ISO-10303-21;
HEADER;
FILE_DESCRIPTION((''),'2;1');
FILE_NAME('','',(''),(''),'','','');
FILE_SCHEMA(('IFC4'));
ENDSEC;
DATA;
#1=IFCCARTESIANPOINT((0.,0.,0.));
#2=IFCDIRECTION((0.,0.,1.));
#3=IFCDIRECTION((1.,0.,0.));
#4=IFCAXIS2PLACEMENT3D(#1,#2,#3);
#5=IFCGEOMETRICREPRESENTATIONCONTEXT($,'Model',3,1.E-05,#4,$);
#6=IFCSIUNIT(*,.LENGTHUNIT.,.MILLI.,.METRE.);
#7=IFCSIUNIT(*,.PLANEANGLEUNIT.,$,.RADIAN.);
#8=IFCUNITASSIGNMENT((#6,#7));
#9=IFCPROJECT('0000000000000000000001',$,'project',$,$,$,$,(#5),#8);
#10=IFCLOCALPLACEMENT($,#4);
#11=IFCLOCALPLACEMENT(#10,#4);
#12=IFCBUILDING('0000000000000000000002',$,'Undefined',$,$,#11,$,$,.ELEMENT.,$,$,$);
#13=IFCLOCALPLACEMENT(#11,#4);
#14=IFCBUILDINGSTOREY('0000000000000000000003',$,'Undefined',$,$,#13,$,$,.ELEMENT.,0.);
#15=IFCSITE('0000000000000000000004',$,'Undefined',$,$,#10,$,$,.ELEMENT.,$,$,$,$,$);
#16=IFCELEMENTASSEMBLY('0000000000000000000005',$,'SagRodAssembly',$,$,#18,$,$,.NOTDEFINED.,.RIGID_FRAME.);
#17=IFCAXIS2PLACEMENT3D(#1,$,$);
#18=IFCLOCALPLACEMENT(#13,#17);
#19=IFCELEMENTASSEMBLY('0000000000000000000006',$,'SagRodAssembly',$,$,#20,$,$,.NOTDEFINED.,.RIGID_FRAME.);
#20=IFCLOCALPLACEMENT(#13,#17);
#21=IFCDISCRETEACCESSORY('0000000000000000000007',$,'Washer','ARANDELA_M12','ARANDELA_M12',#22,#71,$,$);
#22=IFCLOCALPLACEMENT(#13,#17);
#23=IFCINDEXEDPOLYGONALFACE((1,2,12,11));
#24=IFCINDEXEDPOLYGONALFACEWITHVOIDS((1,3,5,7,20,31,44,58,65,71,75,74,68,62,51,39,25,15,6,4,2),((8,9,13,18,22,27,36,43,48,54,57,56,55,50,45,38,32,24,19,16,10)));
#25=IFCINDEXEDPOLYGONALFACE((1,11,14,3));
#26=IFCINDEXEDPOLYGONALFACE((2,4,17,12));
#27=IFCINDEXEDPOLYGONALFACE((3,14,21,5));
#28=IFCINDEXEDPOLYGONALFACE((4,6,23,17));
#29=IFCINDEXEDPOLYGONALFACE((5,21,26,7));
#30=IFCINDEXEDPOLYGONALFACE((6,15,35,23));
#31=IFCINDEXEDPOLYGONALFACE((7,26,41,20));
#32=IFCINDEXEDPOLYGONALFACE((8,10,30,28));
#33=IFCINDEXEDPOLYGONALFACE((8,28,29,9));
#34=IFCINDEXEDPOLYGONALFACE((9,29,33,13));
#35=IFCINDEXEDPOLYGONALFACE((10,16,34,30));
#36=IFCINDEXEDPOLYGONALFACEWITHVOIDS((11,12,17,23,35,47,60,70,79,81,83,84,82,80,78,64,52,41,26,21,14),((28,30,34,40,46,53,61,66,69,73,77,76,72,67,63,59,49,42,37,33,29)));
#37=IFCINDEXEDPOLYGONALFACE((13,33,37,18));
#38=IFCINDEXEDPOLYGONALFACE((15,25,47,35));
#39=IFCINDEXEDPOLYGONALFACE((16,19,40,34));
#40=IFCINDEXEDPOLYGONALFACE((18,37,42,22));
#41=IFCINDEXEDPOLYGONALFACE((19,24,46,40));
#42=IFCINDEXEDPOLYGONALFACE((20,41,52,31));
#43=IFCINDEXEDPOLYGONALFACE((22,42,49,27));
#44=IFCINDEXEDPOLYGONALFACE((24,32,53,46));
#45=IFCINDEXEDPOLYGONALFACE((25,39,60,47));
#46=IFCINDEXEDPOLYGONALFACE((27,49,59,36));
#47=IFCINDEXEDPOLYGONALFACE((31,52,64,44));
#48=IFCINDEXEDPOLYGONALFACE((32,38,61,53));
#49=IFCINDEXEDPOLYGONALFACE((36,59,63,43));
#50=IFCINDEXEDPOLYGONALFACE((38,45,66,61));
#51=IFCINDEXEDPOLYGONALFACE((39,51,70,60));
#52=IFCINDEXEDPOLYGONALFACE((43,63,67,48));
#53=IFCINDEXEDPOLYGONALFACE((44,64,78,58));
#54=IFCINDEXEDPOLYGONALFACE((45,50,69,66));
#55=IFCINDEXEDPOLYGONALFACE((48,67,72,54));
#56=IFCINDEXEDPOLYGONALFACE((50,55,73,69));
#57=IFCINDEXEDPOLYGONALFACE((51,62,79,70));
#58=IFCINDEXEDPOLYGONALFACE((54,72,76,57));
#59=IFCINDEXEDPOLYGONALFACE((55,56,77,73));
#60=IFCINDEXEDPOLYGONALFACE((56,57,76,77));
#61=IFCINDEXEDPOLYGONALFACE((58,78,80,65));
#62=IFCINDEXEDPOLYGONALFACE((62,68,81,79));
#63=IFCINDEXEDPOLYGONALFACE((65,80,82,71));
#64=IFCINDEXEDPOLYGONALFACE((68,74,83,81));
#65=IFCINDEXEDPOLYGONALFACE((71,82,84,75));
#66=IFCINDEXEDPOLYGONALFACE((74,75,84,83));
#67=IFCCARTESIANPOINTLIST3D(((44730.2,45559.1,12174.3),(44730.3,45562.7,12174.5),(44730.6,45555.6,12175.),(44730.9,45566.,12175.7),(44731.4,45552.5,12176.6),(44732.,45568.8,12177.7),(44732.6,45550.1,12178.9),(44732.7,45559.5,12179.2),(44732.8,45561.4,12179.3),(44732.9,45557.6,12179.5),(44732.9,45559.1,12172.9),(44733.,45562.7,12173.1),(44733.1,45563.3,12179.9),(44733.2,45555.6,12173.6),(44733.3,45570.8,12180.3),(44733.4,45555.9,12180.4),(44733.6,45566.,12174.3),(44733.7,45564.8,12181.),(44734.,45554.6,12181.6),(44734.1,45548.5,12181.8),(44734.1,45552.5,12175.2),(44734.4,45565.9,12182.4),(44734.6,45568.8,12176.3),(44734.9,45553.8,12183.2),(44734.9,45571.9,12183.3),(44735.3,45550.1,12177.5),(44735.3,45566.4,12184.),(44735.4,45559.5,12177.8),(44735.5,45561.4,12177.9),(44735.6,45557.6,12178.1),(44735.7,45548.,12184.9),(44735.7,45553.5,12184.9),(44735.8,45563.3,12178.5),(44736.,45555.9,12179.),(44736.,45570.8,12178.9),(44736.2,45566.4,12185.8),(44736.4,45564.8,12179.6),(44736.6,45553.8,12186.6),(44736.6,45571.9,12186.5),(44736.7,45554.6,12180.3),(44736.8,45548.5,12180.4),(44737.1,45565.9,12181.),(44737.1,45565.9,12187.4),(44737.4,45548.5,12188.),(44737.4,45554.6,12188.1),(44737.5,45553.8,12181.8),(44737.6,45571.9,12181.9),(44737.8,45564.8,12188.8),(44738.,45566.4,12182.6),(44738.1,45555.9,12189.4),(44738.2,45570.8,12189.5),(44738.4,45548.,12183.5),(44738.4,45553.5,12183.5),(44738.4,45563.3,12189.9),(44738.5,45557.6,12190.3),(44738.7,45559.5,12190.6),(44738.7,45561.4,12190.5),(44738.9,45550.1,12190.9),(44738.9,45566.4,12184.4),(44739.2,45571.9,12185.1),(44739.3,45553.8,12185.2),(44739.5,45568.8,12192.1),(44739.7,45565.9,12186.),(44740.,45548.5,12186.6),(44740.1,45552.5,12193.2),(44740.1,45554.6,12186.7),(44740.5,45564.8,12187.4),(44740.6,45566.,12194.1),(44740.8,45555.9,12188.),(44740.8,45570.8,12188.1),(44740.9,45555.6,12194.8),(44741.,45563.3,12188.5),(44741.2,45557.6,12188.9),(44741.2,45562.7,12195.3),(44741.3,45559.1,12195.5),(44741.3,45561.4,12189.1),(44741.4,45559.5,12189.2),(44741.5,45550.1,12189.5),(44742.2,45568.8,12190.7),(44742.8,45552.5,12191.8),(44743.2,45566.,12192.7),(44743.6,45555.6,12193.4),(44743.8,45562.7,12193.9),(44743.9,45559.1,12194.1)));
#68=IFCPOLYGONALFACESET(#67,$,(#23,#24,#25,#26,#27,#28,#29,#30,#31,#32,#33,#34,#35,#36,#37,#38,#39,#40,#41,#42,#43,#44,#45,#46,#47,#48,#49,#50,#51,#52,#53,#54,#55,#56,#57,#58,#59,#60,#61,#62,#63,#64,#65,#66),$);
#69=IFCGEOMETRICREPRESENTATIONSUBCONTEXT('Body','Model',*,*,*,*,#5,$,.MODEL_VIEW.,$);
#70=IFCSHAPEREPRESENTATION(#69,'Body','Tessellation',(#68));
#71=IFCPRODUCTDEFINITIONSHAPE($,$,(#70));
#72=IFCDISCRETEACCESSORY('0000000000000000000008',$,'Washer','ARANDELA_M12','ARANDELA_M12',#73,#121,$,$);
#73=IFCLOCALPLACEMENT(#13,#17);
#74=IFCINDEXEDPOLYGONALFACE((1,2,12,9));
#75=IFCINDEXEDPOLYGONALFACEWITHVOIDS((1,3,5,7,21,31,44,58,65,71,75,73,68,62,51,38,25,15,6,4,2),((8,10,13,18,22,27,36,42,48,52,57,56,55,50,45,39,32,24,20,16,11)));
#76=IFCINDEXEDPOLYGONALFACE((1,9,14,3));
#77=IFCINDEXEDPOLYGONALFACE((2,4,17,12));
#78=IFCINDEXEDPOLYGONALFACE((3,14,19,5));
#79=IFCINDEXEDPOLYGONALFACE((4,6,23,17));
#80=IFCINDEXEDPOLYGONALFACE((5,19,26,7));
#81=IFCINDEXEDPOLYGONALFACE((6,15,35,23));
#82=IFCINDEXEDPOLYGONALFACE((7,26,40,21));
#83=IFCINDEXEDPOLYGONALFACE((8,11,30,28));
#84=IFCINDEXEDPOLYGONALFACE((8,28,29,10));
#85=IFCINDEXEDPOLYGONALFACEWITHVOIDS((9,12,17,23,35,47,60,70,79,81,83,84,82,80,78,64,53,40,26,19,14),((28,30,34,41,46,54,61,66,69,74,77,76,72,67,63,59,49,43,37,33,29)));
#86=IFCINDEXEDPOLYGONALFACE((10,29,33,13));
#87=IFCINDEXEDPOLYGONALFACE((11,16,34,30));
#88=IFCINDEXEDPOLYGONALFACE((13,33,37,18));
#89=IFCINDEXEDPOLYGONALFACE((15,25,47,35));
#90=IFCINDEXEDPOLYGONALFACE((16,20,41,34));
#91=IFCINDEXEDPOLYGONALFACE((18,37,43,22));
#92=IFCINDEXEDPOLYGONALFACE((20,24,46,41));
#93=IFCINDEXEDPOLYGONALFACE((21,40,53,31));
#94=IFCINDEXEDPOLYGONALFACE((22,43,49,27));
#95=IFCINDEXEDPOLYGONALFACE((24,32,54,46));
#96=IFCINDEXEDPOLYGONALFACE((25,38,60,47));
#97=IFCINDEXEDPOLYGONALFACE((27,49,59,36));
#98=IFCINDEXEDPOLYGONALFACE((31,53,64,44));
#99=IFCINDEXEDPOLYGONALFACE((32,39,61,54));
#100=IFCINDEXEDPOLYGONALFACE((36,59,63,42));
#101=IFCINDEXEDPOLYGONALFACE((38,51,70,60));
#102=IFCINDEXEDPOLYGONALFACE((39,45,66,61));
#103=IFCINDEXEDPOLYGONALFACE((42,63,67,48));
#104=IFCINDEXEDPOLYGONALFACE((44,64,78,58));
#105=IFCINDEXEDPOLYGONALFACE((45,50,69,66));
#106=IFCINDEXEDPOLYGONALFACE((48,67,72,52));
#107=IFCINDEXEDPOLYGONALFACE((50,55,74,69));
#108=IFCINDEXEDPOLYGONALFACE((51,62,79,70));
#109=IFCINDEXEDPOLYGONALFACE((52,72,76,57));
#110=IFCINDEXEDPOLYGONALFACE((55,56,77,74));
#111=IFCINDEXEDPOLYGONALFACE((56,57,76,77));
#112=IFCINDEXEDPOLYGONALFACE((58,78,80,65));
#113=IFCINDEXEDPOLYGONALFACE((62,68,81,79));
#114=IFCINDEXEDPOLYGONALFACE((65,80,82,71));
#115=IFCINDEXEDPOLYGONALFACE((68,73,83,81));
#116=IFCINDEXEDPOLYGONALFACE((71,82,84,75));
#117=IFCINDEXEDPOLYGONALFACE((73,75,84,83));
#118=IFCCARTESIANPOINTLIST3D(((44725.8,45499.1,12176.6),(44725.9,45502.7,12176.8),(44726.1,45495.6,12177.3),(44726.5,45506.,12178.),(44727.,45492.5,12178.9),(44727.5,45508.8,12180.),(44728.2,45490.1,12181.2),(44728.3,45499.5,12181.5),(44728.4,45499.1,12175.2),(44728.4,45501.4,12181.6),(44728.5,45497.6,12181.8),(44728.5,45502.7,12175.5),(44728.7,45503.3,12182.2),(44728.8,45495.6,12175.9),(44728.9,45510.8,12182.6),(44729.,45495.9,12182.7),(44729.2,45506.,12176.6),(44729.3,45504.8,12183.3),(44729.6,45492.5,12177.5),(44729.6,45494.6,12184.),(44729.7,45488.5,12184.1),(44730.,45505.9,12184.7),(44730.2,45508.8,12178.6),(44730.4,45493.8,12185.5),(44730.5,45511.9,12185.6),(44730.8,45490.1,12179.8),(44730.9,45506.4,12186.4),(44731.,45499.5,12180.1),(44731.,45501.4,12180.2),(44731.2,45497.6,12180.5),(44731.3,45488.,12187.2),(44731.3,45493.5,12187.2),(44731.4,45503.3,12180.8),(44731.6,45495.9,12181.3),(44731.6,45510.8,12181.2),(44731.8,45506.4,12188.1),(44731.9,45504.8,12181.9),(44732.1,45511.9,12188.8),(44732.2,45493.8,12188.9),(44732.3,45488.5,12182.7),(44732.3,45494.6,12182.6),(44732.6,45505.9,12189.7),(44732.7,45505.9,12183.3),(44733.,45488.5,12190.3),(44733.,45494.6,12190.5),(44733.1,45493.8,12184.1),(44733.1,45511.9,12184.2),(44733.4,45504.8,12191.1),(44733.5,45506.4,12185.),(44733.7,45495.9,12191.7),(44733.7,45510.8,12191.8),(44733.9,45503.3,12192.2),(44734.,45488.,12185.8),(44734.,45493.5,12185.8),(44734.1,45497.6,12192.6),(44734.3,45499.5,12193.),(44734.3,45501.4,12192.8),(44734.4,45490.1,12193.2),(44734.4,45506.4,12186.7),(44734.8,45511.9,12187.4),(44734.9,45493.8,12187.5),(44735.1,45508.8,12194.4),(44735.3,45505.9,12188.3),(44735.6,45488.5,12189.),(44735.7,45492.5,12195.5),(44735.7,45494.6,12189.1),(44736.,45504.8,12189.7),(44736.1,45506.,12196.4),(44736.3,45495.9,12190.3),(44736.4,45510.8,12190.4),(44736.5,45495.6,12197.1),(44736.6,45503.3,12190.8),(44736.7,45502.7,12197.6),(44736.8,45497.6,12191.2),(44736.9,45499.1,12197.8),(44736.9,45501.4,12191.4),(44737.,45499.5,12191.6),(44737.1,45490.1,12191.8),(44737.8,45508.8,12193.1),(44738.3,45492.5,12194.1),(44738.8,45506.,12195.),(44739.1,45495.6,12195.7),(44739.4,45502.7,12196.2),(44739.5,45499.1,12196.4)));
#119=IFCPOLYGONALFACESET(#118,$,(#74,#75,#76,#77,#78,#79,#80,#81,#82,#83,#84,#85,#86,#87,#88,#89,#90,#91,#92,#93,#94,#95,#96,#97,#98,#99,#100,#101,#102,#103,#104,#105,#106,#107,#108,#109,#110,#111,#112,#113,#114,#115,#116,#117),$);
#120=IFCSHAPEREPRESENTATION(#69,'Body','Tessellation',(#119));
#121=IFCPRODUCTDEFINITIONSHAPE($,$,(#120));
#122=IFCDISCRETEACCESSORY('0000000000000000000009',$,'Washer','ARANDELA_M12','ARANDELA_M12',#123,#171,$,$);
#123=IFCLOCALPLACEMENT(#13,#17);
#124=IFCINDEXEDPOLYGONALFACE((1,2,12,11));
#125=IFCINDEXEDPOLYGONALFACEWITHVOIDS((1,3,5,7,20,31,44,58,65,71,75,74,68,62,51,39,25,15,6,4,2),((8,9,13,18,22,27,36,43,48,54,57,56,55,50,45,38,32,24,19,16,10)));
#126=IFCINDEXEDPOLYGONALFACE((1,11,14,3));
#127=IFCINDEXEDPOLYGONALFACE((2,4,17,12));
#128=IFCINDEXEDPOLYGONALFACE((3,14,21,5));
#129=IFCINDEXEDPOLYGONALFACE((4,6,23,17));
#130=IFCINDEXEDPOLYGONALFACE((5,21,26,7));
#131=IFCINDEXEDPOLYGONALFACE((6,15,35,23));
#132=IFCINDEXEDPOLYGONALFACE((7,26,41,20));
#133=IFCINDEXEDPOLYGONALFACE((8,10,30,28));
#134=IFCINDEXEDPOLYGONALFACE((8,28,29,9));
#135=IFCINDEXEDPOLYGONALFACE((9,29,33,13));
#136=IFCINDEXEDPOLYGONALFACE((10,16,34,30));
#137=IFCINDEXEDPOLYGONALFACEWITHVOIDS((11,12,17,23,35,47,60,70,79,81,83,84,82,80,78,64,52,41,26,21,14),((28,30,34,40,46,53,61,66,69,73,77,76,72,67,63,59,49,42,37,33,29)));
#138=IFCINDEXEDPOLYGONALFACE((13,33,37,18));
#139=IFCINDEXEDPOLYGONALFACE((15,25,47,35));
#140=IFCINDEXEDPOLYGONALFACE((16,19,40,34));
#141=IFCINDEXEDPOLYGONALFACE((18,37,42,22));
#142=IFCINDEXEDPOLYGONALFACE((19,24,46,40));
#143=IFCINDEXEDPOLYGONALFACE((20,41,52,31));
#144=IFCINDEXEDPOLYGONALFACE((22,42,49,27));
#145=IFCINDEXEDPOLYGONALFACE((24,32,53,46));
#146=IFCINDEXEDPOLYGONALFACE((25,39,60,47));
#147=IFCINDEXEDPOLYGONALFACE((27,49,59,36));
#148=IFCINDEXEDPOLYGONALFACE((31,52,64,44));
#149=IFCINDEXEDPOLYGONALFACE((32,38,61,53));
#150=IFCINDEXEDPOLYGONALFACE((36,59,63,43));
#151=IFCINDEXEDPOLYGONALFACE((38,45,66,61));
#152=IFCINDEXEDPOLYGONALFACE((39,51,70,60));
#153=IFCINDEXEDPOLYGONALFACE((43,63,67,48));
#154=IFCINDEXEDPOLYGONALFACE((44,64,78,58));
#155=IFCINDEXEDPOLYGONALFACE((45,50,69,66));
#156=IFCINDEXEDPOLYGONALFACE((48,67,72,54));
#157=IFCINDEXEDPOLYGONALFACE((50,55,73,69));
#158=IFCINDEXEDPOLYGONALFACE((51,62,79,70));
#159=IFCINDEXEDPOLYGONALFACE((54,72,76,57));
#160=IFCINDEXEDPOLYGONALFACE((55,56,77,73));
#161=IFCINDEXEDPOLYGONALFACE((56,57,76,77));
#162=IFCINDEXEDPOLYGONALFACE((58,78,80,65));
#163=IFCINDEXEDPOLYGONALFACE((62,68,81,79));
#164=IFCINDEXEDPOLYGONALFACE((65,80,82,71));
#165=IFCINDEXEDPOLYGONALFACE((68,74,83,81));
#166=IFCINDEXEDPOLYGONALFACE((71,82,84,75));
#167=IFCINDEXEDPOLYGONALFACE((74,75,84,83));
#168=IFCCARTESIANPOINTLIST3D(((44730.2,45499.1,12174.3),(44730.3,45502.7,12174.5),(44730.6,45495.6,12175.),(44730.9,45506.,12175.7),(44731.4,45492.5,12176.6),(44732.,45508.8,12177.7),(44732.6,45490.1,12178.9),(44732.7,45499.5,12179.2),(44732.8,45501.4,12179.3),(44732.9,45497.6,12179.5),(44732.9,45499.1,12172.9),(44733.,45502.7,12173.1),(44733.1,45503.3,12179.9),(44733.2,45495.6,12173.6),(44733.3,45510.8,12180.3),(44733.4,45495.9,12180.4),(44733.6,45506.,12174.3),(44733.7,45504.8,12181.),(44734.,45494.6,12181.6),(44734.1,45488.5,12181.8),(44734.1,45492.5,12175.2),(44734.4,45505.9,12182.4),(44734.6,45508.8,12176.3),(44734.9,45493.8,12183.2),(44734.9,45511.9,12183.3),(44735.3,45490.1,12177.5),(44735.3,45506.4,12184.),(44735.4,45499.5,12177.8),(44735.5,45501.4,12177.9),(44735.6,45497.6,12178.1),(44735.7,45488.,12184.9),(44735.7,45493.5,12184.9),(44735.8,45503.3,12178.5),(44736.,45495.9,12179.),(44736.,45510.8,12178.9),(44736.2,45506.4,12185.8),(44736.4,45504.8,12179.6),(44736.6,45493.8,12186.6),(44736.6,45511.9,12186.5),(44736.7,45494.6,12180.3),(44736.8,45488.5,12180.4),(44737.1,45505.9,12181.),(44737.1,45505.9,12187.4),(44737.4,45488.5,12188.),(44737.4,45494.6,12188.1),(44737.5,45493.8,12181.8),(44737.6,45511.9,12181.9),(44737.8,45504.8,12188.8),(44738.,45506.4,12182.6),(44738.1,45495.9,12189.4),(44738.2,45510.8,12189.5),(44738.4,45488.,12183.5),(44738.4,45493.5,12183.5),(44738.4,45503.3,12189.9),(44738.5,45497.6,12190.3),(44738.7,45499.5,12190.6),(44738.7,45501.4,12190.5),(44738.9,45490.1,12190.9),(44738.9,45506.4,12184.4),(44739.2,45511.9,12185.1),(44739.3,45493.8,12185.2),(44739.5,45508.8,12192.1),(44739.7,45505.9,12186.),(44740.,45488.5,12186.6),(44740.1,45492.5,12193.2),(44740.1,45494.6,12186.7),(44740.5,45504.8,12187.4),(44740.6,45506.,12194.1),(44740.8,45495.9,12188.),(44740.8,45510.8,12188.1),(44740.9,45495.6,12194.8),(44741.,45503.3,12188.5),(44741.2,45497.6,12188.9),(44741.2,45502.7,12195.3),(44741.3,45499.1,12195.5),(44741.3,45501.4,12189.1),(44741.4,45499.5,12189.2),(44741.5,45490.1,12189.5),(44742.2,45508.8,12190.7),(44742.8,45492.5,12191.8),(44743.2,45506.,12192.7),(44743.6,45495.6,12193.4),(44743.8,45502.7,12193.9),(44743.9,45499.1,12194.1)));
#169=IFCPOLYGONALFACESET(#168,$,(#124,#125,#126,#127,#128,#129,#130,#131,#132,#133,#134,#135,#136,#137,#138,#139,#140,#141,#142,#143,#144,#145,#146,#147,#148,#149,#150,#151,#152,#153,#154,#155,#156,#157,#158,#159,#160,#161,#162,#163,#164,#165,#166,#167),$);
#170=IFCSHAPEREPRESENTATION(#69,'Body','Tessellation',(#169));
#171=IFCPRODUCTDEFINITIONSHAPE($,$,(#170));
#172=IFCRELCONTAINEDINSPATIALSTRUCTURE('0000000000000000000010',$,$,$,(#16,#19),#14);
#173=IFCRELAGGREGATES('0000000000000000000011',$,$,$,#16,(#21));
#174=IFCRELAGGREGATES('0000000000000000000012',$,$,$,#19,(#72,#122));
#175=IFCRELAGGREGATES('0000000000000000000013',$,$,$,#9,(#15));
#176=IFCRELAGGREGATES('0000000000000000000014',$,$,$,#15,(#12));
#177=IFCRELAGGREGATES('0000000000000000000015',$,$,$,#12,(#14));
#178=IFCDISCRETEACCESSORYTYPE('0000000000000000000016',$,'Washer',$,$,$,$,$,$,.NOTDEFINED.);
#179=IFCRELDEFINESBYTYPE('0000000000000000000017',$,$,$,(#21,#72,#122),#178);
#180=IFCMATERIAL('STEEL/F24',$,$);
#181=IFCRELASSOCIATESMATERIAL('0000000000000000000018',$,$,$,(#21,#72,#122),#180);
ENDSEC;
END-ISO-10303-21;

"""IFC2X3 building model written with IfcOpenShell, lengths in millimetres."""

from ifc_helpers import new_model, si_unit, frame, origin_with_axes, origin_2d_with_axis, place, context, subcontext, project, spatial, hollow_circle, extrude, material, type_object, element, aggregate, save


model = new_model("IFC2X3")

# Units and contexts
model_context = context("Model", 3, precision=1e-05, world=origin_with_axes())
body_context = subcontext(model_context, "Body", "Model", "MODEL_VIEW")
ifc_project = project(units=[si_unit("LENGTHUNIT", "METRE", prefix="MILLI"), si_unit("PLANEANGLEUNIT", "RADIAN")], contexts=[model_context])

# Site, building, storey
site_placement = place(None, origin_with_axes())
site = spatial("IfcSite", under=ifc_project, at=site_placement, Name="Undefined", CompositionType="ELEMENT")
building_placement = place(site_placement, origin_with_axes())
building = spatial("IfcBuilding", under=site, at=building_placement, Name="Undefined", CompositionType="ELEMENT")
storey_placement = place(building_placement, origin_with_axes())
storey = spatial("IfcBuildingStorey", under=building, at=storey_placement, Name="Undefined", CompositionType="ELEMENT", Elevation=0.0)

# Element assemblies
assembly_1_placement = place(storey_placement, origin_with_axes())
assembly_1 = element("IfcElementAssembly", 1, at=assembly_1_placement, inside=storey, Name="SagRodAssembly", AssemblyPlace="NOTDEFINED", PredefinedType="RIGID_FRAME")
ifc_material_1 = material(Name="STEEL/F24")
assembly_2_placement = place(storey_placement, origin_with_axes())
assembly_2 = element("IfcElementAssembly", 2, at=assembly_2_placement, inside=storey, Name="SagRodAssembly", AssemblyPlace="NOTDEFINED", PredefinedType="RIGID_FRAME")

# Discrete accessories
discrete_accessory_type_1 = type_object("IfcDiscreteAccessoryType", Name="Washer")
discrete_accessory_1_placement = place(assembly_1_placement, frame((44738.4, 45560.0, 12183.5), z_axis=(-0.463578, 0.0, -0.886056), x_axis=(-0.886056, 0.0, 0.463578)))
discrete_accessory_1 = element("IfcDiscreteAccessory", 3, at=discrete_accessory_1_placement, type_object=discrete_accessory_type_1, material=ifc_material_1, Name="Washer", Description="ARANDELA_M12", ObjectType="ARANDELA_M12", context=body_context, shape_type="SweptSolid", body=[
    extrude(hollow_circle(Radius=12.0, WallThickness=5.5, at=origin_2d_with_axis()), frame((3.0, 0.0, 0.0), z_axis=(-1.0, 0.0, 0.0), x_axis=(0.0, -1.0, 0.0)), (0.0, 0.0, 1.0), 3.0),
])
aggregate(assembly_1, [discrete_accessory_1])
discrete_accessory_2_placement = place(assembly_2_placement, frame((44734.0, 45500.0, 12185.8), z_axis=(-0.463578, 0.0, -0.886056), x_axis=(-0.886056, 0.0, 0.463578)))
discrete_accessory_2 = element("IfcDiscreteAccessory", 4, at=discrete_accessory_2_placement, type_object=discrete_accessory_type_1, material=ifc_material_1, Name="Washer", Description="ARANDELA_M12", ObjectType="ARANDELA_M12", context=body_context, shape_type="SweptSolid", body=[
    extrude(hollow_circle(Radius=12.0, WallThickness=5.5, at=origin_2d_with_axis()), frame((3.0, 0.0, 0.0), z_axis=(-1.0, 0.0, 0.0), x_axis=(0.0, -1.0, 0.0)), (0.0, 0.0, 1.0), 3.0),
])
discrete_accessory_3_placement = place(assembly_2_placement, frame((44738.4, 45500.0, 12183.5), z_axis=(-0.463578, 0.0, -0.886056), x_axis=(-0.886056, 0.0, 0.463578)))
discrete_accessory_3 = element("IfcDiscreteAccessory", 5, at=discrete_accessory_3_placement, type_object=discrete_accessory_type_1, material=ifc_material_1, Name="Washer", Description="ARANDELA_M12", ObjectType="ARANDELA_M12", context=body_context, shape_type="SweptSolid", body=[
    extrude(hollow_circle(Radius=12.0, WallThickness=5.5, at=origin_2d_with_axis()), frame((3.0, 0.0, 0.0), z_axis=(-1.0, 0.0, 0.0), x_axis=(0.0, -1.0, 0.0)), (0.0, 0.0, 1.0), 3.0),
])
aggregate(assembly_2, [discrete_accessory_2, discrete_accessory_3])

save(model, "model.ifc")
